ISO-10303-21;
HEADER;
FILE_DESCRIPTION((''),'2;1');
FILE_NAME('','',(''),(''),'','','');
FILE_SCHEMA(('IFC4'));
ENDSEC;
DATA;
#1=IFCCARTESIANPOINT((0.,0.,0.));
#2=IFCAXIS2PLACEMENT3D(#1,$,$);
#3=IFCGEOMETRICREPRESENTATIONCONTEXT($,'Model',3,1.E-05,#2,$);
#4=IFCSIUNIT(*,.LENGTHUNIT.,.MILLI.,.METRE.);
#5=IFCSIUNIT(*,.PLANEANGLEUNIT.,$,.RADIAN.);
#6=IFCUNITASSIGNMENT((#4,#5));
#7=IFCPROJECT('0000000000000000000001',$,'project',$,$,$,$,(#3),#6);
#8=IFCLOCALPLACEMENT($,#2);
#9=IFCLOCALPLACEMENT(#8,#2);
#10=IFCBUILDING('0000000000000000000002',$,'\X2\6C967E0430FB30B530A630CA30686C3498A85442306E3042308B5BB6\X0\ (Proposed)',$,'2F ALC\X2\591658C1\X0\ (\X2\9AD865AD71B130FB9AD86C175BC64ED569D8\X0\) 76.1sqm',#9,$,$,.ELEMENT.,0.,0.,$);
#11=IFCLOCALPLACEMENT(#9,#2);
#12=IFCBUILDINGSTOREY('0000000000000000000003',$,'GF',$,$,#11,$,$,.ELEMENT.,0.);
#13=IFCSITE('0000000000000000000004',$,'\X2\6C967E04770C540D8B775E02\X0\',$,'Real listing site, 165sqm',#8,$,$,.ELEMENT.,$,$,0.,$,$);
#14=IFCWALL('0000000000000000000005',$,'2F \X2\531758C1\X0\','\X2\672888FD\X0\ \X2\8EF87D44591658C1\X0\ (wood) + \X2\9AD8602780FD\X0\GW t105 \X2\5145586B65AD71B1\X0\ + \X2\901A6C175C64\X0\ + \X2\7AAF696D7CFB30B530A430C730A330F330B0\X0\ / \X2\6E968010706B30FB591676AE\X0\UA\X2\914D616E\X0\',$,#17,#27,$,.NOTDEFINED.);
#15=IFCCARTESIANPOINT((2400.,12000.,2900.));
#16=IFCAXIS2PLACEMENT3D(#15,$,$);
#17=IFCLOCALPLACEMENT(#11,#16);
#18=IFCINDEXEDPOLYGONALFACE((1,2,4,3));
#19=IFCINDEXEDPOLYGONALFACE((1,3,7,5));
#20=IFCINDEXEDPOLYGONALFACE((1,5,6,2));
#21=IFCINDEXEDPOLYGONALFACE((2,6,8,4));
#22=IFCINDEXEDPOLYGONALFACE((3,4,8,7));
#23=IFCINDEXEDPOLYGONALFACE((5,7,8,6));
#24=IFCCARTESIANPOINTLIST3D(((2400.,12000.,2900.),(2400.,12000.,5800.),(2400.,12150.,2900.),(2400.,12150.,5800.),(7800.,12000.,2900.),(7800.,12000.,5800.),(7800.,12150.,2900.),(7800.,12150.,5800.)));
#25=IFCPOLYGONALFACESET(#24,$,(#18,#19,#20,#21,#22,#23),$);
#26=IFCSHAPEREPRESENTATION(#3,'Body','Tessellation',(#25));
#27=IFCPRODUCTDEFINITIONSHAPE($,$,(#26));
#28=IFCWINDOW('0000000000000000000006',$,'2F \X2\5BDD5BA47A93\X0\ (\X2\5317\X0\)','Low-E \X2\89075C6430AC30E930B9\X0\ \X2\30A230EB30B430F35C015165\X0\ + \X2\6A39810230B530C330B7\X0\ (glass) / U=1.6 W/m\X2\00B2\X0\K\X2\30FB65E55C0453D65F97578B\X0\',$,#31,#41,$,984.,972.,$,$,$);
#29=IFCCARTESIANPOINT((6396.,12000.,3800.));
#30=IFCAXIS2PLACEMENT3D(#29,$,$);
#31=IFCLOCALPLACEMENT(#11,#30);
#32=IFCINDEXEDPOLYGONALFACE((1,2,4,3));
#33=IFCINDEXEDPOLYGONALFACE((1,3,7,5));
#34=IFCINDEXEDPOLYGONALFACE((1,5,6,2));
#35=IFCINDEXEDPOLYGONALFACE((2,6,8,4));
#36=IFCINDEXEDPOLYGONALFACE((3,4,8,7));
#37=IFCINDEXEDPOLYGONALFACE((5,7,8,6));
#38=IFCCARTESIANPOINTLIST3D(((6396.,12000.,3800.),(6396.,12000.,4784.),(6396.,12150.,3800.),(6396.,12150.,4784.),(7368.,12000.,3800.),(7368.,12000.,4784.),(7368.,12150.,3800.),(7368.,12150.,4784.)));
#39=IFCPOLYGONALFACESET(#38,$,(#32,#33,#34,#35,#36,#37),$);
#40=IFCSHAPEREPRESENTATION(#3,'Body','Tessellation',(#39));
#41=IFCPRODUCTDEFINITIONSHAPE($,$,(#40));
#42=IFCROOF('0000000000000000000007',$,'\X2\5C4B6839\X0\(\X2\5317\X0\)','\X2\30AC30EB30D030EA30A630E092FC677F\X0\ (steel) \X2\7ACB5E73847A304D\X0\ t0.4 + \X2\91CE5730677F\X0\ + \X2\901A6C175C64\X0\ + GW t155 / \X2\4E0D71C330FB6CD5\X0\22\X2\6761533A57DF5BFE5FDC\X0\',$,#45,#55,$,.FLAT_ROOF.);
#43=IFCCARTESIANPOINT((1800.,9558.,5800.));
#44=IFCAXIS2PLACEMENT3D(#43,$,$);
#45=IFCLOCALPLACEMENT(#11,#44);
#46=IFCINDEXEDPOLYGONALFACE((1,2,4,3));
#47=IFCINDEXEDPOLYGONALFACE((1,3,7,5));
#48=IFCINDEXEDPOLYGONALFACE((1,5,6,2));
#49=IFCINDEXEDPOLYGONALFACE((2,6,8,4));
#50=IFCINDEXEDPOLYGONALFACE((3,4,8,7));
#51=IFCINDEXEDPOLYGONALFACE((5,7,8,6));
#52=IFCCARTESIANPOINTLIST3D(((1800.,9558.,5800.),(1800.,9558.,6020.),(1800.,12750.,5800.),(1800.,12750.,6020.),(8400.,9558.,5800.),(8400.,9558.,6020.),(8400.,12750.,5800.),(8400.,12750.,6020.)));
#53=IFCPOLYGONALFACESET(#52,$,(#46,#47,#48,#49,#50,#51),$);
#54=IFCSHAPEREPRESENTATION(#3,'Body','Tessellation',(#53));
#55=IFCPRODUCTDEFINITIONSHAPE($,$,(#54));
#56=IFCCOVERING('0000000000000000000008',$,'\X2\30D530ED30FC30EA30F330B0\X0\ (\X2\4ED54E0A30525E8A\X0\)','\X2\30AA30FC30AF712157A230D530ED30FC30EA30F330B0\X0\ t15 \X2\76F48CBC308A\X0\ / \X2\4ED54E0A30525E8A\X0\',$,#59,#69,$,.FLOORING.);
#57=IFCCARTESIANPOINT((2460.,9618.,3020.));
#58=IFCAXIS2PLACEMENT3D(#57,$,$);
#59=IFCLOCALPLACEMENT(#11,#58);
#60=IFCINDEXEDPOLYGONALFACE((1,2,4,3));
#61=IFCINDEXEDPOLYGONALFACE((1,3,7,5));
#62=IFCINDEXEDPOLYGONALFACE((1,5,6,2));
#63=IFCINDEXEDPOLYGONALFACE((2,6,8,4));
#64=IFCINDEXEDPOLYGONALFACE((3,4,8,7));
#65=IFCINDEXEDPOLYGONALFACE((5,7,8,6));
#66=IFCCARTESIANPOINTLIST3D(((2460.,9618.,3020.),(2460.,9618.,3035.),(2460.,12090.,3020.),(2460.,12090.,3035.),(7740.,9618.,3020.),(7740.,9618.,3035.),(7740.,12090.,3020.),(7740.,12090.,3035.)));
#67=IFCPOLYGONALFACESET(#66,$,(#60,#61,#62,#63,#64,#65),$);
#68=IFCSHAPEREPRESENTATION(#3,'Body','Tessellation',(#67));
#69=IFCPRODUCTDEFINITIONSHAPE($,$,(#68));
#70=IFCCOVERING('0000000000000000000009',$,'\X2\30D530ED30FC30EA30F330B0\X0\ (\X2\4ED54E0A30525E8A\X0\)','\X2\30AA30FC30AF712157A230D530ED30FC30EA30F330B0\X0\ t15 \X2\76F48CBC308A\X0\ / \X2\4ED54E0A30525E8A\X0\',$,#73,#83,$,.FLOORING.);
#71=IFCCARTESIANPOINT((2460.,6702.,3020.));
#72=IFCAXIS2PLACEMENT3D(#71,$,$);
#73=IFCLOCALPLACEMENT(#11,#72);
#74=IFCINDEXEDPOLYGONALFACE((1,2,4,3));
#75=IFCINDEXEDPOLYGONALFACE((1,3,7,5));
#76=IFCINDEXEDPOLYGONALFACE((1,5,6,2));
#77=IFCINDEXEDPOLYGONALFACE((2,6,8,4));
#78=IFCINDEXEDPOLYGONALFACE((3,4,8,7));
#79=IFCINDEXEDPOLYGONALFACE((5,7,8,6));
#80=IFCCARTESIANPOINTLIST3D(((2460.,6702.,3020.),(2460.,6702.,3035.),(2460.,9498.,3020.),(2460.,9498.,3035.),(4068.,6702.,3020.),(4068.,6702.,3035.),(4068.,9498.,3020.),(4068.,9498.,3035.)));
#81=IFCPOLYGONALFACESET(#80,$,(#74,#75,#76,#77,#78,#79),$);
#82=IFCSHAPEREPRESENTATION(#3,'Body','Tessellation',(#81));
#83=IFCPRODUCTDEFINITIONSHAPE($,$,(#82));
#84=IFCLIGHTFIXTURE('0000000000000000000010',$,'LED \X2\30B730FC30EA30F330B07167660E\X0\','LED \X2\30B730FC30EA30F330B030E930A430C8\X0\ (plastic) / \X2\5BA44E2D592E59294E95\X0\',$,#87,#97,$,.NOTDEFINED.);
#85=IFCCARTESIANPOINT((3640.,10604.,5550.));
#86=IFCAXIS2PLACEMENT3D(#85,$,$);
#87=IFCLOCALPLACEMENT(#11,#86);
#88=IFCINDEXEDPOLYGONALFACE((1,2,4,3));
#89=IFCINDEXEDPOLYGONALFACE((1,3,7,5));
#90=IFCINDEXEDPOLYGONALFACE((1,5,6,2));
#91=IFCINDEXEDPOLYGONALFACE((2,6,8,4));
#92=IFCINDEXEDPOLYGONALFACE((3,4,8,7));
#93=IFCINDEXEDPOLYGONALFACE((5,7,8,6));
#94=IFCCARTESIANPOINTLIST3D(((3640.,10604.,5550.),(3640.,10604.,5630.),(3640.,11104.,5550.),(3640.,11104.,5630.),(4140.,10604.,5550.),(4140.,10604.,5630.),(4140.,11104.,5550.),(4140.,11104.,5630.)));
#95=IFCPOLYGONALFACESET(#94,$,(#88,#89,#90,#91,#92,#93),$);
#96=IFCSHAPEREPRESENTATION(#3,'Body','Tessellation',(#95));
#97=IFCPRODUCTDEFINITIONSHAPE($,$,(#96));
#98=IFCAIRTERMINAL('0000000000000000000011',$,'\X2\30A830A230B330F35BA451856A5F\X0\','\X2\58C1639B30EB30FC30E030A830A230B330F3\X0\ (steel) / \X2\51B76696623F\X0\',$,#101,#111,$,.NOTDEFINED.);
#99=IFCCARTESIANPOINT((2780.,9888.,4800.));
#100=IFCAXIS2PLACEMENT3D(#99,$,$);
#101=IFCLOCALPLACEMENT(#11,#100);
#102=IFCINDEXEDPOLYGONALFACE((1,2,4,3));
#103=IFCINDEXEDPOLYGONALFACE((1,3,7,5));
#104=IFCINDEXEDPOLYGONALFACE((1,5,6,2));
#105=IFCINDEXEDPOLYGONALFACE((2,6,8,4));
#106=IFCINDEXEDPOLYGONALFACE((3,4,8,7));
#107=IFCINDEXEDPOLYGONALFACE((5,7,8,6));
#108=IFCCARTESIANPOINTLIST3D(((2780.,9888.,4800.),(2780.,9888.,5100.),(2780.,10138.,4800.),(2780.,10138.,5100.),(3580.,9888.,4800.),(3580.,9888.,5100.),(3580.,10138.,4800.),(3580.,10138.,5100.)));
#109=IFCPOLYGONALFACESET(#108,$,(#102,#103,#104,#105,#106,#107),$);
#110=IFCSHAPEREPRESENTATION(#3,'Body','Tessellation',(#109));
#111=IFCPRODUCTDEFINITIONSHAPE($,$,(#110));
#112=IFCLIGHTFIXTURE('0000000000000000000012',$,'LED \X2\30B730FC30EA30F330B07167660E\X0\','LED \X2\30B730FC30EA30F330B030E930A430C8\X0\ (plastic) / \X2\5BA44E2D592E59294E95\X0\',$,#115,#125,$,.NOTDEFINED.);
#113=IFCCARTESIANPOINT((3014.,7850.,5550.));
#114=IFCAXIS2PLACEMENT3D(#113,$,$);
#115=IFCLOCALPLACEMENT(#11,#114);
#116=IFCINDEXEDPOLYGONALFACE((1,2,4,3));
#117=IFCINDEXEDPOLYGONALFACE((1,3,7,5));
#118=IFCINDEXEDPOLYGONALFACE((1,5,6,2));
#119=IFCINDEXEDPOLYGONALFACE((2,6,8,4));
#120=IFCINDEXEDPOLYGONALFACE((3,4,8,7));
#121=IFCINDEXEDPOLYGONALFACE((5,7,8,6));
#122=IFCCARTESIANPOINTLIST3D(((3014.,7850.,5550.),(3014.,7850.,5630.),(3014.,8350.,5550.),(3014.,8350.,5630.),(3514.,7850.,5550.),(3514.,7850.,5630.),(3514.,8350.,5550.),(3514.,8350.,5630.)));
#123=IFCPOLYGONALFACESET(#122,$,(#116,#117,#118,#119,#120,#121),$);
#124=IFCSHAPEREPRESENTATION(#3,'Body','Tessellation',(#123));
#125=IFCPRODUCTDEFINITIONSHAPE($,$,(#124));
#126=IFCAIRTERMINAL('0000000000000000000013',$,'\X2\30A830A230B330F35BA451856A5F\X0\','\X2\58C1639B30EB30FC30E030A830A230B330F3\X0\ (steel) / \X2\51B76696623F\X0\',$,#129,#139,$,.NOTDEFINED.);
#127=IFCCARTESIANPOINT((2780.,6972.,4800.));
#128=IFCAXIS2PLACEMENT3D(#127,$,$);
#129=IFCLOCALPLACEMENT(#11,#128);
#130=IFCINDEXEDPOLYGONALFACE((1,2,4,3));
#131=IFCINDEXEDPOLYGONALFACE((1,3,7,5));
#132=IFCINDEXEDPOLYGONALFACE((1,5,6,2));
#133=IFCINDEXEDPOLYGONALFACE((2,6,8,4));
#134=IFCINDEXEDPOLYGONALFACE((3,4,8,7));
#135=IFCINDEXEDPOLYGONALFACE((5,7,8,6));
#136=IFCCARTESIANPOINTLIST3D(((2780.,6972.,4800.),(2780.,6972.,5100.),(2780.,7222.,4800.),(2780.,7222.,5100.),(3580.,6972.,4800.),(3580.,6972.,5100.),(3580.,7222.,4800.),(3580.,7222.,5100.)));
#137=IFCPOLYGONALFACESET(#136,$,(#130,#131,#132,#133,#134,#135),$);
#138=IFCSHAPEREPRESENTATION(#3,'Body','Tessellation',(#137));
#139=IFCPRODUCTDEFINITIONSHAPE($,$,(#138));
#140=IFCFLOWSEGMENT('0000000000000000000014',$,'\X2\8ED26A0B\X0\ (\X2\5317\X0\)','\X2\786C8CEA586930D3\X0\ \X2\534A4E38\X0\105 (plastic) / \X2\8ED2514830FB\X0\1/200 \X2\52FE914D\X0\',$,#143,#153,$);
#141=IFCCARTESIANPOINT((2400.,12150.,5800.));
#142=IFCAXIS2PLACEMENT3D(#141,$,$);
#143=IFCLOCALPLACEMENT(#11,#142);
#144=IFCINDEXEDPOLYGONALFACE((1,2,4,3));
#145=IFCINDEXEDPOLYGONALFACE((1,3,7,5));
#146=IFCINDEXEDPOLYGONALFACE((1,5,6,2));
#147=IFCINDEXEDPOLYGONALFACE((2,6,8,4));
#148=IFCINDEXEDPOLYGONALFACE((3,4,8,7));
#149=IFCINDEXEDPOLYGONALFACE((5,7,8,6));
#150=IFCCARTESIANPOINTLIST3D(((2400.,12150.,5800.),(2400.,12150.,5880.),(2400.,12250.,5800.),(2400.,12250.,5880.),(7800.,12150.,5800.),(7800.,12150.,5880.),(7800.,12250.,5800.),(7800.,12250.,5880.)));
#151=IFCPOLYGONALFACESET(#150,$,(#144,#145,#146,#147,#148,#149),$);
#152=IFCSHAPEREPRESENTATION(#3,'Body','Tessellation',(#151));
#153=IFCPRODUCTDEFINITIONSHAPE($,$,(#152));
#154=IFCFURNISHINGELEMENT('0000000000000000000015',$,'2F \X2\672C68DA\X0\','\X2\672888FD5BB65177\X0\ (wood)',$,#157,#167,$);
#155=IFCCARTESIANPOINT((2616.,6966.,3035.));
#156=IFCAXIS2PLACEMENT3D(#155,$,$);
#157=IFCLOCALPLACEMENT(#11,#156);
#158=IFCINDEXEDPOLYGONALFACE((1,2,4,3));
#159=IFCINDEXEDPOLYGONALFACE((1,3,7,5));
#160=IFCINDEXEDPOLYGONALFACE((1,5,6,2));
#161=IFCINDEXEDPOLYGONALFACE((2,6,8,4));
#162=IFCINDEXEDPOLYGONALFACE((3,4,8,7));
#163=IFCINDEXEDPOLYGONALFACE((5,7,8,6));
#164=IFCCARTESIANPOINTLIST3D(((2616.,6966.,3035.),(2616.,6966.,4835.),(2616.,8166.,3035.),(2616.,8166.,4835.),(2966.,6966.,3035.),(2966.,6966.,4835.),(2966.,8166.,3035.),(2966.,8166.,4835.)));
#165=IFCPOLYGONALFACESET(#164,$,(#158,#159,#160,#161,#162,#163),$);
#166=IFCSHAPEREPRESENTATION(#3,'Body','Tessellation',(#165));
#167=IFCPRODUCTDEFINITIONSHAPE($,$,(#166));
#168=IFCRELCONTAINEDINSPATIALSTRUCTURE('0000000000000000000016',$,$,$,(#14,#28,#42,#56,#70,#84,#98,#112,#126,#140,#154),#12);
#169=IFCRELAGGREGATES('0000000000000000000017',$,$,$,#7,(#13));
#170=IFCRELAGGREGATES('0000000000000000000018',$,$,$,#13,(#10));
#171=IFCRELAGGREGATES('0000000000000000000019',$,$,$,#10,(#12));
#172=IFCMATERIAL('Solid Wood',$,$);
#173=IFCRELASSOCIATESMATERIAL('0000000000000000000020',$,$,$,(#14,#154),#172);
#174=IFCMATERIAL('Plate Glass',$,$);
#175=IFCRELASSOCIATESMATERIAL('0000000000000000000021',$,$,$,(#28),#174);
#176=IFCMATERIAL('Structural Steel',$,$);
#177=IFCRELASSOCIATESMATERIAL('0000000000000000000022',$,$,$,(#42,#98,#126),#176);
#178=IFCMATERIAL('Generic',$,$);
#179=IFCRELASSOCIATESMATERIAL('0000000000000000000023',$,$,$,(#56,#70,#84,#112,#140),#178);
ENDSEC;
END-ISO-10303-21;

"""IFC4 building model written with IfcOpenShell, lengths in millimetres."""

from ifc_helpers import new_model, si_unit, frame, frame_2d, origin, place, context, project, spatial, rectangle, extrude, material, element, fill, save


model = new_model("IFC4")

# Units and contexts
model_context = context("Model", 3, precision=1e-05, world=origin())
ifc_project = project(units=[si_unit("LENGTHUNIT", "METRE", prefix="MILLI"), si_unit("PLANEANGLEUNIT", "RADIAN")], contexts=[model_context])

# Site, building, storey
site_placement = place(None, origin())
site = spatial("IfcSite", under=ifc_project, at=site_placement, Name="沖縄県名護市", ObjectType="Real listing site, 165sqm", CompositionType="ELEMENT", RefElevation=0.0)
building_placement = place(site_placement, origin())
building = spatial("IfcBuilding", under=site, at=building_placement, Name="沖縄・サウナと水風呂のある家 (Proposed)", ObjectType="2F ALC外壁 (高断熱・高気密仕様) 76.1sqm", CompositionType="ELEMENT", ElevationOfRefHeight=0.0, ElevationOfTerrain=0.0)
storey_placement = place(building_placement, origin())
storey = spatial("IfcBuildingStorey", under=building, at=storey_placement, Name="GF", CompositionType="ELEMENT", Elevation=0.0)

# Shared definitions
ifc_material_1 = material(Name="Solid Wood")

# Wall, opening, window
wall_placement = place(storey_placement, frame((2400.0, 12000.0, 2900.0)))
wall = element("IfcWall", 1, at=wall_placement, inside=storey, material=ifc_material_1, Name="2F 北壁", Description="木製 軸組外壁 (wood) + 高性能GW t105 充填断熱 + 通気層 + 窯業系サイディング / 準耐火・外皮UA配慮", PredefinedType="NOTDEFINED", context=model_context, shape_type="SweptSolid", body=[
    extrude(rectangle(XDim=5400.0, YDim=150.0, at=frame_2d((2700.0, 75.0))), frame((2400.0, 12000.0, 2900.0)), (0.0, 0.0, 1.0), 2900.0),
])
opening_placement = place(storey_placement, frame((6396.0, 12000.0, 3800.0)))
opening = element("IfcOpeningElement", 2, at=opening_placement, cuts=wall, PredefinedType="NOTDEFINED", context=model_context, shape_type="SweptSolid", body=[
    extrude(rectangle(XDim=972.0, YDim=150.0, at=frame_2d((486.0, 75.0))), frame((6396.0, 12000.0, 3800.0)), (0.0, 0.0, 1.0), 984.0),
])
ifc_material_2 = material(Name="Plate Glass")
window_placement = place(storey_placement, frame((6396.0, 12000.0, 3800.0)))
window = element("IfcWindow", 3, at=window_placement, inside=storey, material=ifc_material_2, Name="2F 寝室窓 (北)", Description="Low-E 複層ガラス アルゴン封入 + 樹脂サッシ (glass) / U=1.6 W/m²K・日射取得型", OverallHeight=984.0, OverallWidth=972.0, context=model_context, shape_type="SweptSolid", body=[
    extrude(rectangle(XDim=972.0, YDim=150.0, at=frame_2d((486.0, 75.0))), frame((6396.0, 12000.0, 3800.0)), (0.0, 0.0, 1.0), 984.0),
])
fill(opening, window)

# Roof
ifc_material_3 = material(Name="Structural Steel")
for number, where, name in (
    (4, (1800.0, 9558.0, 5800.0), "屋根(北)"),
):
    element("IfcRoof", number, at=place(storey_placement, frame(where)), inside=storey, material=ifc_material_3, Name=name, Description="ガルバリウム鋼板 (steel) 立平葺き t0.4 + 野地板 + 通気層 + GW t155 / 不燃・法22条区域対応", PredefinedType="FLAT_ROOF", context=model_context, shape_type="SweptSolid", body=[
        extrude(rectangle(XDim=6600.0, YDim=3192.0, at=frame_2d((3300.0, 1596.0))), frame((1800.0, 9558.0, 5800.0)), (0.0, 0.0, 1.0), 220.0),
    ])

# Coverings
ifc_material_4 = material(Name="Generic")
covering_1_placement = place(storey_placement, frame((2460.0, 9618.0, 3020.0)))
element("IfcCovering", 5, at=covering_1_placement, inside=storey, material=ifc_material_4, Name="フローリング (仕上げ床)", Description="オーク無垢フローリング t15 直貼り / 仕上げ床", PredefinedType="FLOORING", context=model_context, shape_type="SweptSolid", body=[
    extrude(rectangle(XDim=5280.0, YDim=2472.0, at=frame_2d((2640.0, 1236.0))), frame((2460.0, 9618.0, 3020.0)), (0.0, 0.0, 1.0), 15.0),
])
covering_2_placement = place(storey_placement, frame((2460.0, 6702.0, 3020.0)))
element("IfcCovering", 6, at=covering_2_placement, inside=storey, material=ifc_material_4, Name="フローリング (仕上げ床)", Description="オーク無垢フローリング t15 直貼り / 仕上げ床", PredefinedType="FLOORING", context=model_context, shape_type="SweptSolid", body=[
    extrude(rectangle(XDim=1608.0, YDim=2796.0, at=frame_2d((804.0, 1398.0))), frame((2460.0, 6702.0, 3020.0)), (0.0, 0.0, 1.0), 15.0),
])

# Light fixture
light_fixture_1_placement = place(storey_placement, frame((3640.0, 10604.0, 5550.0)))
element("IfcLightFixture", 7, at=light_fixture_1_placement, inside=storey, material=ifc_material_4, Name="LED シーリング照明", Description="LED シーリングライト (plastic) / 室中央天井", PredefinedType="NOTDEFINED", context=model_context, shape_type="SweptSolid", body=[
    extrude(rectangle(XDim=500.0, YDim=500.0, at=frame_2d((250.0, 250.0))), frame((3640.0, 10604.0, 5550.0)), (0.0, 0.0, 1.0), 80.0),
])

# Air terminal
air_terminal_1_placement = place(storey_placement, frame((2780.0, 9888.0, 4800.0)))
element("IfcAirTerminal", 8, at=air_terminal_1_placement, inside=storey, material=ifc_material_3, Name="エアコン室内機", Description="壁掛ルームエアコン (steel) / 冷暖房", PredefinedType="NOTDEFINED", context=model_context, shape_type="SweptSolid", body=[
    extrude(rectangle(XDim=800.0, YDim=250.0, at=frame_2d((400.0, 125.0))), frame((2780.0, 9888.0, 4800.0)), (0.0, 0.0, 1.0), 300.0),
])

# Light fixture
light_fixture_2_placement = place(storey_placement, frame((3014.0, 7850.0, 5550.0)))
element("IfcLightFixture", 9, at=light_fixture_2_placement, inside=storey, material=ifc_material_4, Name="LED シーリング照明", Description="LED シーリングライト (plastic) / 室中央天井", PredefinedType="NOTDEFINED", context=model_context, shape_type="SweptSolid", body=[
    extrude(rectangle(XDim=500.0, YDim=500.0, at=frame_2d((250.0, 250.0))), frame((3014.0, 7850.0, 5550.0)), (0.0, 0.0, 1.0), 80.0),
])

# Air terminal
air_terminal_2_placement = place(storey_placement, frame((2780.0, 6972.0, 4800.0)))
element("IfcAirTerminal", 10, at=air_terminal_2_placement, inside=storey, material=ifc_material_3, Name="エアコン室内機", Description="壁掛ルームエアコン (steel) / 冷暖房", PredefinedType="NOTDEFINED", context=model_context, shape_type="SweptSolid", body=[
    extrude(rectangle(XDim=800.0, YDim=250.0, at=frame_2d((400.0, 125.0))), frame((2780.0, 6972.0, 4800.0)), (0.0, 0.0, 1.0), 300.0),
])

# Flow segment
flow_segment_placement = place(storey_placement, frame((2400.0, 12150.0, 5800.0)))
element("IfcFlowSegment", 11, at=flow_segment_placement, inside=storey, material=ifc_material_4, Name="軒樋 (北)", Description="硬質塩ビ 半丸105 (plastic) / 軒先・1/200 勾配", context=model_context, shape_type="SweptSolid", body=[
    extrude(rectangle(XDim=5400.0, YDim=100.0, at=frame_2d((2700.0, 50.0))), frame((2400.0, 12150.0, 5800.0)), (0.0, 0.0, 1.0), 80.0),
])

# Furnishing element
furnishing_placement = place(storey_placement, frame((2616.0, 6966.0, 3035.0)))
element("IfcFurnishingElement", 12, at=furnishing_placement, inside=storey, material=ifc_material_1, Name="2F 本棚", Description="木製家具 (wood)", context=model_context, shape_type="SweptSolid", body=[
    extrude(rectangle(XDim=350.0, YDim=1200.0, at=frame_2d((175.0, 600.0))), frame((2616.0, 6966.0, 3035.0)), (0.0, 0.0, 1.0), 1800.0),
])

save(model, "model.ifc")
